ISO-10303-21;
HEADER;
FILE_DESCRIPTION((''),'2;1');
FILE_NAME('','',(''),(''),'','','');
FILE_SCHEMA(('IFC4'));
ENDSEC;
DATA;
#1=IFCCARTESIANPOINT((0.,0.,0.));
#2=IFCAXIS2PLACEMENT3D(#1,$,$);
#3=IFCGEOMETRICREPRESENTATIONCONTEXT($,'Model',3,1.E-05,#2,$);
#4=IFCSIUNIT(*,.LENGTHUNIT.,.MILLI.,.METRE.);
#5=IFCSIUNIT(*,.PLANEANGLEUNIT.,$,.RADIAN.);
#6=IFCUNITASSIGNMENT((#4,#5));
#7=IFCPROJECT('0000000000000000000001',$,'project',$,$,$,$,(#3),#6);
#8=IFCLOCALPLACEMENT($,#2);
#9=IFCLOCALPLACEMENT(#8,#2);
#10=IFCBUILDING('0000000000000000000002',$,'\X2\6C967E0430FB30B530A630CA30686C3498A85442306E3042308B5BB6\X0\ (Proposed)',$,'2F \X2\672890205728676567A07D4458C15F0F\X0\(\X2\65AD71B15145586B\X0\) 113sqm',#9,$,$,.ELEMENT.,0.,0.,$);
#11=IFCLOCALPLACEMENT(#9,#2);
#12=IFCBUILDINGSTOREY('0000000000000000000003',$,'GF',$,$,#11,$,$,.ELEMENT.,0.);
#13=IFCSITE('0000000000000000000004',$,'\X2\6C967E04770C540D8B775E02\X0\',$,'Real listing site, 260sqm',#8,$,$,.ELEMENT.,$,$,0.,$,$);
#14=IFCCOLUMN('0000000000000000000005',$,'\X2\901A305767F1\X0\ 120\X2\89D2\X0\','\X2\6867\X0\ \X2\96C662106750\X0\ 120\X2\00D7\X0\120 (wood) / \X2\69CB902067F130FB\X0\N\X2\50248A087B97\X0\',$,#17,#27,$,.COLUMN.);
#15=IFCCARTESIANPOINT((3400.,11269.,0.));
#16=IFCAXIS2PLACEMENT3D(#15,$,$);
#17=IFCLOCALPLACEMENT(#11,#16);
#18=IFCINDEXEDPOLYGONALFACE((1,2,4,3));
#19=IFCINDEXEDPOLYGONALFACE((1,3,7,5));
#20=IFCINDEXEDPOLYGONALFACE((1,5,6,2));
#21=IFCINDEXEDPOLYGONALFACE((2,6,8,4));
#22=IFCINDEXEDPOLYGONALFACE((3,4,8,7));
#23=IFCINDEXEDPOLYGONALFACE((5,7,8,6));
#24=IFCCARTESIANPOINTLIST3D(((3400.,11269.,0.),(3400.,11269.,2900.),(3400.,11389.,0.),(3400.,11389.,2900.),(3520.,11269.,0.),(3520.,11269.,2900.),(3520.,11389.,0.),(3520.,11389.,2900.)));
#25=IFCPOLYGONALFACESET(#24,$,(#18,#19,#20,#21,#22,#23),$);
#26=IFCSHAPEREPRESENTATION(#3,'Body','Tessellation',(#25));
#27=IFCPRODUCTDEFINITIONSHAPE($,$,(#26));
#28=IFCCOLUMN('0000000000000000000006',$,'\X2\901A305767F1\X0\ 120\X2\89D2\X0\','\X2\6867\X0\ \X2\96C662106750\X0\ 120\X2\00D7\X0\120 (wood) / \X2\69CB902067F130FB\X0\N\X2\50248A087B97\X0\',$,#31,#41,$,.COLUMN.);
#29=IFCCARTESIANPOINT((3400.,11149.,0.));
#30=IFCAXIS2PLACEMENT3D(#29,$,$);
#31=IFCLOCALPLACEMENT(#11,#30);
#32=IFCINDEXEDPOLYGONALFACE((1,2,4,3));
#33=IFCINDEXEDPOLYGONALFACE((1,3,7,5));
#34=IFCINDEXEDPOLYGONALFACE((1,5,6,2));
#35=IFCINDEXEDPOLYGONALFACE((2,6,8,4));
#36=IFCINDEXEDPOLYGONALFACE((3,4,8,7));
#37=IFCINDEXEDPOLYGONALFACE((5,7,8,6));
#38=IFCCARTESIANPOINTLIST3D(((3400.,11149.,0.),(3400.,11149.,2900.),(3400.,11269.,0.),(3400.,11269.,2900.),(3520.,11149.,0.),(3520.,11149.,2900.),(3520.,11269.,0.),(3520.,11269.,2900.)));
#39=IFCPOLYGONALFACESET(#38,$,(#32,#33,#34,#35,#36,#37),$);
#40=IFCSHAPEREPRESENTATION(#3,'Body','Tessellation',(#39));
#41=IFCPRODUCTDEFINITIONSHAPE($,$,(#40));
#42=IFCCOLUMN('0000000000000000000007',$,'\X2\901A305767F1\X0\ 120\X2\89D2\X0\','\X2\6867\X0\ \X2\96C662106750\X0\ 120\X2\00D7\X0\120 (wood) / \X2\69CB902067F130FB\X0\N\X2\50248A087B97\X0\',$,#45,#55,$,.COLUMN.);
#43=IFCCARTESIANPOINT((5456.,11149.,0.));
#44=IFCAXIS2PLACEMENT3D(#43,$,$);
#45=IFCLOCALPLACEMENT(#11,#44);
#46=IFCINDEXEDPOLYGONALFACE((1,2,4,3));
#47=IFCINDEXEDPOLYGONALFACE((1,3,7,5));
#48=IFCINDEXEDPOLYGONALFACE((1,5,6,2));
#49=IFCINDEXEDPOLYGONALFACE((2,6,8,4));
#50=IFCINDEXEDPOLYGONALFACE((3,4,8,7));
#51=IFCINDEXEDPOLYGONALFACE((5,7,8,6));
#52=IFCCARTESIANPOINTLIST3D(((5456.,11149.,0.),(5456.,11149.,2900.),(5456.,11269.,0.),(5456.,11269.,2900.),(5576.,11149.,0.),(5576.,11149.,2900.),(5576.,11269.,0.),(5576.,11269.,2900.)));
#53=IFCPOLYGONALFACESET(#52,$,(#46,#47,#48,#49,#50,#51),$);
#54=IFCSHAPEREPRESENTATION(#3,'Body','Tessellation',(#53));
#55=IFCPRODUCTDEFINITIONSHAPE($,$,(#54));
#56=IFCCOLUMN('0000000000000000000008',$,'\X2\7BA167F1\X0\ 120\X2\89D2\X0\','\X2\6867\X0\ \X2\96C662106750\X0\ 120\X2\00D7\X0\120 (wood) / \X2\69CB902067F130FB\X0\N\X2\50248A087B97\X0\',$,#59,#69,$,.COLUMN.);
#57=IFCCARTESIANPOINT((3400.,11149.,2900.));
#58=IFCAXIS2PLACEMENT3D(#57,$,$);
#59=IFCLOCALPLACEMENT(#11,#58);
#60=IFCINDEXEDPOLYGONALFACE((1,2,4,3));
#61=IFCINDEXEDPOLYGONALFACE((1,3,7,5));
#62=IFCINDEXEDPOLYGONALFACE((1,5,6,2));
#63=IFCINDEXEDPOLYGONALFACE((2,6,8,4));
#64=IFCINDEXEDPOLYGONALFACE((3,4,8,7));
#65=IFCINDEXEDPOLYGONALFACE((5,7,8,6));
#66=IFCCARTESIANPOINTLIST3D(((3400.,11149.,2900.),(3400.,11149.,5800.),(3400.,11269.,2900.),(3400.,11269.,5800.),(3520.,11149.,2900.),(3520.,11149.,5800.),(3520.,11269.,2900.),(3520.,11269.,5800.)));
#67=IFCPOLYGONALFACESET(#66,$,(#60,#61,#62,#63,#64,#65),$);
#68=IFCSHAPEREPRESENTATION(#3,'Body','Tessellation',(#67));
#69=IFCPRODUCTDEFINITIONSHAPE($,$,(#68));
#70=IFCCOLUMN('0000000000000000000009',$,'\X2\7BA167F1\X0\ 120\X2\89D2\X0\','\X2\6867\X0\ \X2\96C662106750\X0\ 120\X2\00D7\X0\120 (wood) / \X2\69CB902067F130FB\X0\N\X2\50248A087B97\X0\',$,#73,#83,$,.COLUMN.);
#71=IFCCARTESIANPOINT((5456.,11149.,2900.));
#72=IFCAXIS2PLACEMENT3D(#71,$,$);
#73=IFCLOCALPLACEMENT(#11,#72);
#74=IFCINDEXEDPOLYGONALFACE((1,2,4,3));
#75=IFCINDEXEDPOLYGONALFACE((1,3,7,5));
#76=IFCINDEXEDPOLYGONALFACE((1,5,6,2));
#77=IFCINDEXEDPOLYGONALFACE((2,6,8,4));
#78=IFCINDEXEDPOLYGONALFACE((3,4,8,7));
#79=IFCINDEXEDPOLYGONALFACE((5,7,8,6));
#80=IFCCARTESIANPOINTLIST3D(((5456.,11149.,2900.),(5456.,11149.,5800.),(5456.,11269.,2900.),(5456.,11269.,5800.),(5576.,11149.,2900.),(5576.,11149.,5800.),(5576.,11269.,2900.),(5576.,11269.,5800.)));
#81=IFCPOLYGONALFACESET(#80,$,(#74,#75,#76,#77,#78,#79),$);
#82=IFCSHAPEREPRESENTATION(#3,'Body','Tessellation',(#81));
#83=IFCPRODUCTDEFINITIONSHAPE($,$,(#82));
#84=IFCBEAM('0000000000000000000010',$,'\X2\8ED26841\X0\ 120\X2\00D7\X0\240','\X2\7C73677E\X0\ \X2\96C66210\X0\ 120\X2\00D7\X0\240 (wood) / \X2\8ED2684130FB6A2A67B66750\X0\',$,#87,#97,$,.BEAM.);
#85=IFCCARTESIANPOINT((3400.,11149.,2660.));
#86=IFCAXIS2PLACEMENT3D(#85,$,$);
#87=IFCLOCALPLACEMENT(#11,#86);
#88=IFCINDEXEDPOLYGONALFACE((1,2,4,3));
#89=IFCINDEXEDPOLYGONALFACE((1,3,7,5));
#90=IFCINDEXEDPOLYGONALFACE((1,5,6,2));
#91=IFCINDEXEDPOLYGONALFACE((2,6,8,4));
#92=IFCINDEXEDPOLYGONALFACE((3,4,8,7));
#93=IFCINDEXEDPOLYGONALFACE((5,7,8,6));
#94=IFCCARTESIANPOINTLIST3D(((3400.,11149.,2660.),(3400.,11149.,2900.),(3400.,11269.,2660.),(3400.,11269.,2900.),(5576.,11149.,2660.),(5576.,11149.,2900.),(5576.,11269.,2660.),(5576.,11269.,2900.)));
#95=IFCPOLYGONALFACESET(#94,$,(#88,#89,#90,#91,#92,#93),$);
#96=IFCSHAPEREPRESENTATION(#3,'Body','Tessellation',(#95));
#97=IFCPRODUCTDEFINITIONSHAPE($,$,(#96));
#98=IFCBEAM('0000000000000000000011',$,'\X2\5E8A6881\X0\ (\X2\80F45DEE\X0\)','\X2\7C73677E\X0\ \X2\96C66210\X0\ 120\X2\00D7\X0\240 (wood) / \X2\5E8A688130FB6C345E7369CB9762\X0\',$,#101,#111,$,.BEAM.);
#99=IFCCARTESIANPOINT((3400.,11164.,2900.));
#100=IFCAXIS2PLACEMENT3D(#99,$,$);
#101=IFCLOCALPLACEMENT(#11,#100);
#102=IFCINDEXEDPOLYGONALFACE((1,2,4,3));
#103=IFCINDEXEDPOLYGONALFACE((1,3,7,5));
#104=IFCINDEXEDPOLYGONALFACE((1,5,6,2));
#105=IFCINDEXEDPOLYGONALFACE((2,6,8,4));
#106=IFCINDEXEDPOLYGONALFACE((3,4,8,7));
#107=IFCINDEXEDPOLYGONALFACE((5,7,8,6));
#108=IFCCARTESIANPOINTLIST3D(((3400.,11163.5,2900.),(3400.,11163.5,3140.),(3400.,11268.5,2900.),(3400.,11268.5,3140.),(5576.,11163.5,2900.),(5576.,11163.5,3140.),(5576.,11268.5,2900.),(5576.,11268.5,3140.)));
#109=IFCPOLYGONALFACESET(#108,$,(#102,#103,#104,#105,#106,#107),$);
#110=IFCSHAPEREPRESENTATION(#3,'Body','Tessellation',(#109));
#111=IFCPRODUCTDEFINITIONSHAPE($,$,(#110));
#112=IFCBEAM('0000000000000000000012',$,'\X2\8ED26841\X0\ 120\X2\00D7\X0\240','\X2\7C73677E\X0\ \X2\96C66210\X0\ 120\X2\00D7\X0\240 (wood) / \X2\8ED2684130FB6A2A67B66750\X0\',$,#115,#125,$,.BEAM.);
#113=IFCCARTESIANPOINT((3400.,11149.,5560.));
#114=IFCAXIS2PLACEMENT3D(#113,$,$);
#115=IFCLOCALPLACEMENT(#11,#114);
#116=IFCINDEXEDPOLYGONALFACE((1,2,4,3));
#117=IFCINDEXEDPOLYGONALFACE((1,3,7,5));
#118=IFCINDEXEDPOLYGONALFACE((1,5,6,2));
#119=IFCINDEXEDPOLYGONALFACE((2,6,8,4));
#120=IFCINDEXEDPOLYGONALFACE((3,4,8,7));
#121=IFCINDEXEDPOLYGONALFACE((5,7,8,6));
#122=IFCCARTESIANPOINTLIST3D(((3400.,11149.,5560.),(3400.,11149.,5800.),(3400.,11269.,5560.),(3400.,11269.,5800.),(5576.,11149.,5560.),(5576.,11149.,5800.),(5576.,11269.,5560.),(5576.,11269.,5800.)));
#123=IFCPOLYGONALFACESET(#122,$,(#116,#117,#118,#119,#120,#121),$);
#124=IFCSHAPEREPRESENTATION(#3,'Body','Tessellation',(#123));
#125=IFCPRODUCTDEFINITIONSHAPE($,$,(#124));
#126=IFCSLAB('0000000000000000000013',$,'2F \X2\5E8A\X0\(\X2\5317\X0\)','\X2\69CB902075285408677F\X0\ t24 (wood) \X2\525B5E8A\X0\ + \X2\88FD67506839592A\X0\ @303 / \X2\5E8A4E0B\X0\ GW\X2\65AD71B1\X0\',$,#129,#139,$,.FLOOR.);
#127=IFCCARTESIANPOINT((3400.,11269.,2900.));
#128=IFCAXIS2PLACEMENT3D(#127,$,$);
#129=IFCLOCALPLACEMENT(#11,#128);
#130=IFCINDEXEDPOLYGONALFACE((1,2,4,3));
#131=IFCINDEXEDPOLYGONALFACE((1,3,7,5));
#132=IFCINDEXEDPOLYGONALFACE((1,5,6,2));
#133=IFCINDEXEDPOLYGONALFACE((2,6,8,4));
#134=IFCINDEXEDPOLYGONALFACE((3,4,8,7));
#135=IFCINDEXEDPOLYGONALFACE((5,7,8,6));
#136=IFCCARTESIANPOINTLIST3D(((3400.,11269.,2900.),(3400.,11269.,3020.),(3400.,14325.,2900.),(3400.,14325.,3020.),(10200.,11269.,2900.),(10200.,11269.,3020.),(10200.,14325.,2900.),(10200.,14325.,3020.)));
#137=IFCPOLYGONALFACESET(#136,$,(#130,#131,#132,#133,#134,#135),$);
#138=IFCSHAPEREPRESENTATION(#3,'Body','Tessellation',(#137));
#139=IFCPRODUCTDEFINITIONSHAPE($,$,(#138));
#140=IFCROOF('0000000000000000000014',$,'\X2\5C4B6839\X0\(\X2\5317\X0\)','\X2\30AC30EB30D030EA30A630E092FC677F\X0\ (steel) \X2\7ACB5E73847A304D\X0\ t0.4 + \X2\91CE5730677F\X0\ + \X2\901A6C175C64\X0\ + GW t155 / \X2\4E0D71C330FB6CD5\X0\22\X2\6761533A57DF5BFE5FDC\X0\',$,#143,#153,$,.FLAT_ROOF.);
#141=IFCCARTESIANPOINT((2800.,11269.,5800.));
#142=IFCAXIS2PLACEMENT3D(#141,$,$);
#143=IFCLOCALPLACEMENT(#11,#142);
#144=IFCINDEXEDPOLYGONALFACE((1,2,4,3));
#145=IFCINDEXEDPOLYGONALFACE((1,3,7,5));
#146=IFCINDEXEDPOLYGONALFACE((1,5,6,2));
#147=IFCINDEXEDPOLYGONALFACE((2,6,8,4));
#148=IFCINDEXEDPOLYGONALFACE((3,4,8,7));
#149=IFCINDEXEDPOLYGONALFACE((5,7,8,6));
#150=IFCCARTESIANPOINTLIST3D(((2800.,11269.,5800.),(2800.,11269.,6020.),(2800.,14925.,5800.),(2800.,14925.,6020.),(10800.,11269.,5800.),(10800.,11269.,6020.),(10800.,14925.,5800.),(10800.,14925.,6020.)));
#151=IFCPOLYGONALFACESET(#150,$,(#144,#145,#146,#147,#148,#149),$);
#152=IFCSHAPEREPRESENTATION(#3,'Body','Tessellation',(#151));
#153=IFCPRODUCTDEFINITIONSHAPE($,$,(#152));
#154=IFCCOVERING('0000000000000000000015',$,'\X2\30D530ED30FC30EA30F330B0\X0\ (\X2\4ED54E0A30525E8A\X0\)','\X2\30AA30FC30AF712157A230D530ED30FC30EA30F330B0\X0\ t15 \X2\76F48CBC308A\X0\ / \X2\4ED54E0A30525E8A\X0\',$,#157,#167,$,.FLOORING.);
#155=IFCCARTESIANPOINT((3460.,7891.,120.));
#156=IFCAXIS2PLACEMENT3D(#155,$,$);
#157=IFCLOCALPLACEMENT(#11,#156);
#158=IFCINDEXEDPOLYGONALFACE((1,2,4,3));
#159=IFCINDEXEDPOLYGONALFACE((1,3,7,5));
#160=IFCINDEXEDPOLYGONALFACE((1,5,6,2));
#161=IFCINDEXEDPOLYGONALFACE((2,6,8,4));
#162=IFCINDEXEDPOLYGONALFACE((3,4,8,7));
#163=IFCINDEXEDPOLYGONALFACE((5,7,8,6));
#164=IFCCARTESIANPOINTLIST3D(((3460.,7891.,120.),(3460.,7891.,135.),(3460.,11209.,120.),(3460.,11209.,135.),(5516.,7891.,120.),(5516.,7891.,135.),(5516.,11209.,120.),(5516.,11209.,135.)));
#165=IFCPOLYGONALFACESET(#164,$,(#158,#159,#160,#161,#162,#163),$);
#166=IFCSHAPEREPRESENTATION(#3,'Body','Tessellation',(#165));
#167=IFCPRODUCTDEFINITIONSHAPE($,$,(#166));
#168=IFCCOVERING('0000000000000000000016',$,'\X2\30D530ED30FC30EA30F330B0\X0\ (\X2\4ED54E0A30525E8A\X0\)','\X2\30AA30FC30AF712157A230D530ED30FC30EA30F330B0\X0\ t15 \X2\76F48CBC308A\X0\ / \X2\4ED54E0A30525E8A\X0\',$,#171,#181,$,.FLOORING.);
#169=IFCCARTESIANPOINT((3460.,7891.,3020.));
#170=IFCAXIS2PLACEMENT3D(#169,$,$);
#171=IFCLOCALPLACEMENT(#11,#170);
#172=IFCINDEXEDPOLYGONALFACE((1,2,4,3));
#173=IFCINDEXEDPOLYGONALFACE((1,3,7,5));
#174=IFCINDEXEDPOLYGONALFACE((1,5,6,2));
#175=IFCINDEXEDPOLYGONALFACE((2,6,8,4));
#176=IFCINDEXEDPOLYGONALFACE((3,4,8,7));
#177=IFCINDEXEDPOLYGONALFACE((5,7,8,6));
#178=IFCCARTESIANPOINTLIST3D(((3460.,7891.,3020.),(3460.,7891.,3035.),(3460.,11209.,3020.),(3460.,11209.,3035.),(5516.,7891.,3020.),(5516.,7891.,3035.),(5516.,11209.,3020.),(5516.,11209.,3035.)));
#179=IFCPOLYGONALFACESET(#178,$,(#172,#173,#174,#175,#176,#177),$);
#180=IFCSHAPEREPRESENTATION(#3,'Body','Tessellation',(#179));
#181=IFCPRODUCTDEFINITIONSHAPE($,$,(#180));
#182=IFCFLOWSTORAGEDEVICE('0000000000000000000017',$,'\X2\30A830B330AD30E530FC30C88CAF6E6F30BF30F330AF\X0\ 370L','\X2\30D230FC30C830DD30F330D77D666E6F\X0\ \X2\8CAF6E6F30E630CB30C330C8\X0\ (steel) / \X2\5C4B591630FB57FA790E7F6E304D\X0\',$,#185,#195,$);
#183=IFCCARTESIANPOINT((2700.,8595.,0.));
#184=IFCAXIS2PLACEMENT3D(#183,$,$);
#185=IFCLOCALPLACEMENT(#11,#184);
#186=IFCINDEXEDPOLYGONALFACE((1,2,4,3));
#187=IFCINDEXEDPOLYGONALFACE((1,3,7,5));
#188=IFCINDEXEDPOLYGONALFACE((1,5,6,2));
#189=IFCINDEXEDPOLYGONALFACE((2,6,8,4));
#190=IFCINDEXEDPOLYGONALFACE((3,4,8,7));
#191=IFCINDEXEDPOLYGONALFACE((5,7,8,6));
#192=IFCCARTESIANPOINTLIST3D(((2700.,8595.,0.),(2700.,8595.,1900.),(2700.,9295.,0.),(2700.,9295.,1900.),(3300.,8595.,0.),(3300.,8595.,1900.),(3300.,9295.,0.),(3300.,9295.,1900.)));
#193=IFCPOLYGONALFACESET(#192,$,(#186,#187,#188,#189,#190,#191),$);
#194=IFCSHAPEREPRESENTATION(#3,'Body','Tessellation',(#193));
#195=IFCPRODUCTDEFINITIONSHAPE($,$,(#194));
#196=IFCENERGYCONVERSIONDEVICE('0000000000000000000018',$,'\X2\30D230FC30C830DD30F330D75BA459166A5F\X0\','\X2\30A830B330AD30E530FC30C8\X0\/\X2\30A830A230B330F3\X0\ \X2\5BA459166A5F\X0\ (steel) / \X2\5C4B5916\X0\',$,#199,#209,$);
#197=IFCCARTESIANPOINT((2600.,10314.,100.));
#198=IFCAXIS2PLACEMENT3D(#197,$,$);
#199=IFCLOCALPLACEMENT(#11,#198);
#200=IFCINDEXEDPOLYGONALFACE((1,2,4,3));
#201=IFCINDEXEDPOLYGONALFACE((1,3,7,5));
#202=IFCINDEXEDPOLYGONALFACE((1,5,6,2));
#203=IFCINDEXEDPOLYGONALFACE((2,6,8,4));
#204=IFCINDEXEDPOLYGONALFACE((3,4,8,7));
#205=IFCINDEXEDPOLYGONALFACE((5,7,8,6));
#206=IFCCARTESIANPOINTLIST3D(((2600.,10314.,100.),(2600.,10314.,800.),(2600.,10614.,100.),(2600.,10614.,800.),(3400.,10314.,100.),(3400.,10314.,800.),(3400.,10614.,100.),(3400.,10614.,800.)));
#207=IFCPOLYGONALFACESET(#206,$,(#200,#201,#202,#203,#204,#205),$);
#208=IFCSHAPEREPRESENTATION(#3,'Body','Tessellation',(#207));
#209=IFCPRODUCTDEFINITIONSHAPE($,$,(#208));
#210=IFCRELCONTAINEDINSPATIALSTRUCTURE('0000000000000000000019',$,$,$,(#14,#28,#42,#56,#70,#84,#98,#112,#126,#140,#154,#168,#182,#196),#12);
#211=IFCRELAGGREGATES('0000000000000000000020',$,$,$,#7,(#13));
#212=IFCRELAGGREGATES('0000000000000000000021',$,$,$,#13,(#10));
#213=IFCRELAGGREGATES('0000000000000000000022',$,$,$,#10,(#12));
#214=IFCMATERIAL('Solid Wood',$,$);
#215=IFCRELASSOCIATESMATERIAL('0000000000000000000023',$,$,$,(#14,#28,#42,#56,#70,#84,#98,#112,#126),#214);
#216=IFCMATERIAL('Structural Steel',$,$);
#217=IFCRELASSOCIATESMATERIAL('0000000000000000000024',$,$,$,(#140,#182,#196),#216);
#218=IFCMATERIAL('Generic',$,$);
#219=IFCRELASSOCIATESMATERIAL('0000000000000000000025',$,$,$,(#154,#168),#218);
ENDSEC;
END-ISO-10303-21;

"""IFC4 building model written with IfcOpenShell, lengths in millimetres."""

from ifc_helpers import new_model, si_unit, frame, frame_2d, origin, place, context, project, spatial, rectangle, extrude, material, element, save


model = new_model("IFC4")

# Units and contexts
model_context = context("Model", 3, precision=1e-05, world=origin())
ifc_project = project(units=[si_unit("LENGTHUNIT", "METRE", prefix="MILLI"), si_unit("PLANEANGLEUNIT", "RADIAN")], contexts=[model_context])

# Site, building, storey
site_placement = place(None, origin())
site = spatial("IfcSite", under=ifc_project, at=site_placement, Name="沖縄県名護市", ObjectType="Real listing site, 260sqm", CompositionType="ELEMENT", RefElevation=0.0)
building_placement = place(site_placement, origin())
building = spatial("IfcBuilding", under=site, at=building_placement, Name="沖縄・サウナと水風呂のある家 (Proposed)", ObjectType="2F 木造在来枠組壁式(断熱充填) 113sqm", CompositionType="ELEMENT", ElevationOfRefHeight=0.0, ElevationOfTerrain=0.0)
storey_placement = place(building_placement, origin())
storey = spatial("IfcBuildingStorey", under=building, at=storey_placement, Name="GF", CompositionType="ELEMENT", Elevation=0.0)

# Columns
ifc_material_1 = material(Name="Solid Wood")
column_1_placement = place(storey_placement, frame((3400.0, 11269.0, 0.0)))
element("IfcColumn", 1, at=column_1_placement, inside=storey, material=ifc_material_1, Name="通し柱 120角", Description="桧 集成材 120×120 (wood) / 構造柱・N値計算", PredefinedType="COLUMN", context=model_context, shape_type="SweptSolid", body=[
    extrude(rectangle(XDim=120.0, YDim=120.0, at=frame_2d((60.0, 60.0))), frame((3400.0, 11269.0, 0.0)), (0.0, 0.0, 1.0), 2900.0),
])
column_2_placement = place(storey_placement, frame((3400.0, 11149.0, 0.0)))
element("IfcColumn", 2, at=column_2_placement, inside=storey, material=ifc_material_1, Name="通し柱 120角", Description="桧 集成材 120×120 (wood) / 構造柱・N値計算", PredefinedType="COLUMN", context=model_context, shape_type="SweptSolid", body=[
    extrude(rectangle(XDim=120.0, YDim=120.0, at=frame_2d((60.0, 60.0))), frame((3400.0, 11149.0, 0.0)), (0.0, 0.0, 1.0), 2900.0),
])
column_3_placement = place(storey_placement, frame((5456.0, 11149.0, 0.0)))
element("IfcColumn", 3, at=column_3_placement, inside=storey, material=ifc_material_1, Name="通し柱 120角", Description="桧 集成材 120×120 (wood) / 構造柱・N値計算", PredefinedType="COLUMN", context=model_context, shape_type="SweptSolid", body=[
    extrude(rectangle(XDim=120.0, YDim=120.0, at=frame_2d((60.0, 60.0))), frame((5456.0, 11149.0, 0.0)), (0.0, 0.0, 1.0), 2900.0),
])
column_4_placement = place(storey_placement, frame((3400.0, 11149.0, 2900.0)))
element("IfcColumn", 4, at=column_4_placement, inside=storey, material=ifc_material_1, Name="管柱 120角", Description="桧 集成材 120×120 (wood) / 構造柱・N値計算", PredefinedType="COLUMN", context=model_context, shape_type="SweptSolid", body=[
    extrude(rectangle(XDim=120.0, YDim=120.0, at=frame_2d((60.0, 60.0))), frame((3400.0, 11149.0, 2900.0)), (0.0, 0.0, 1.0), 2900.0),
])
column_5_placement = place(storey_placement, frame((5456.0, 11149.0, 2900.0)))
element("IfcColumn", 5, at=column_5_placement, inside=storey, material=ifc_material_1, Name="管柱 120角", Description="桧 集成材 120×120 (wood) / 構造柱・N値計算", PredefinedType="COLUMN", context=model_context, shape_type="SweptSolid", body=[
    extrude(rectangle(XDim=120.0, YDim=120.0, at=frame_2d((60.0, 60.0))), frame((5456.0, 11149.0, 2900.0)), (0.0, 0.0, 1.0), 2900.0),
])

# Beams
beam_1_placement = place(storey_placement, frame((3400.0, 11149.0, 2660.0)))
element("IfcBeam", 6, at=beam_1_placement, inside=storey, material=ifc_material_1, Name="軒桁 120×240", Description="米松 集成 120×240 (wood) / 軒桁・横架材", PredefinedType="BEAM", context=model_context, shape_type="SweptSolid", body=[
    extrude(rectangle(XDim=2176.0, YDim=120.0, at=frame_2d((1088.0, 60.0))), frame((3400.0, 11149.0, 2660.0)), (0.0, 0.0, 1.0), 240.0),
])
beam_2_placement = place(storey_placement, frame((3400.0, 11164.0, 2900.0)))
element("IfcBeam", 7, at=beam_2_placement, inside=storey, material=ifc_material_1, Name="床梁 (胴差)", Description="米松 集成 120×240 (wood) / 床梁・水平構面", PredefinedType="BEAM", context=model_context, shape_type="SweptSolid", body=[
    extrude(rectangle(XDim=2176.0, YDim=105.0, at=frame_2d((1088.0, 52.0))), frame((3400.0, 11164.0, 2900.0)), (0.0, 0.0, 1.0), 240.0),
])
beam_3_placement = place(storey_placement, frame((3400.0, 11149.0, 5560.0)))
element("IfcBeam", 8, at=beam_3_placement, inside=storey, material=ifc_material_1, Name="軒桁 120×240", Description="米松 集成 120×240 (wood) / 軒桁・横架材", PredefinedType="BEAM", context=model_context, shape_type="SweptSolid", body=[
    extrude(rectangle(XDim=2176.0, YDim=120.0, at=frame_2d((1088.0, 60.0))), frame((3400.0, 11149.0, 5560.0)), (0.0, 0.0, 1.0), 240.0),
])

# Slab
slab_1_placement = place(storey_placement, frame((3400.0, 11269.0, 2900.0)))
element("IfcSlab", 9, at=slab_1_placement, inside=storey, material=ifc_material_1, Name="2F 床(北)", Description="構造用合板 t24 (wood) 剛床 + 製材根太 @303 / 床下 GW断熱", PredefinedType="FLOOR", context=model_context, shape_type="SweptSolid", body=[
    extrude(rectangle(XDim=6800.0, YDim=3056.0, at=frame_2d((3400.0, 1528.0))), frame((3400.0, 11269.0, 2900.0)), (0.0, 0.0, 1.0), 120.0),
])

# Roof
ifc_material_2 = material(Name="Structural Steel")
for number, where, name in (
    (10, (2800.0, 11269.0, 5800.0), "屋根(北)"),
):
    element("IfcRoof", number, at=place(storey_placement, frame(where)), inside=storey, material=ifc_material_2, Name=name, Description="ガルバリウム鋼板 (steel) 立平葺き t0.4 + 野地板 + 通気層 + GW t155 / 不燃・法22条区域対応", PredefinedType="FLAT_ROOF", context=model_context, shape_type="SweptSolid", body=[
        extrude(rectangle(XDim=8000.0, YDim=3656.0, at=frame_2d((4000.0, 1828.0))), frame((2800.0, 11269.0, 5800.0)), (0.0, 0.0, 1.0), 220.0),
    ])

# Coverings
ifc_material_3 = material(Name="Generic")
covering_1_placement = place(storey_placement, frame((3460.0, 7891.0, 120.0)))
element("IfcCovering", 11, at=covering_1_placement, inside=storey, material=ifc_material_3, Name="フローリング (仕上げ床)", Description="オーク無垢フローリング t15 直貼り / 仕上げ床", PredefinedType="FLOORING", context=model_context, shape_type="SweptSolid", body=[
    extrude(rectangle(XDim=2056.0, YDim=3318.0, at=frame_2d((1028.0, 1659.0))), frame((3460.0, 7891.0, 120.0)), (0.0, 0.0, 1.0), 15.0),
])
covering_2_placement = place(storey_placement, frame((3460.0, 7891.0, 3020.0)))
element("IfcCovering", 12, at=covering_2_placement, inside=storey, material=ifc_material_3, Name="フローリング (仕上げ床)", Description="オーク無垢フローリング t15 直貼り / 仕上げ床", PredefinedType="FLOORING", context=model_context, shape_type="SweptSolid", body=[
    extrude(rectangle(XDim=2056.0, YDim=3318.0, at=frame_2d((1028.0, 1659.0))), frame((3460.0, 7891.0, 3020.0)), (0.0, 0.0, 1.0), 15.0),
])

# Flow storage device
flow_storage_device_placement = place(storey_placement, frame((2700.0, 8595.0, 0.0)))
element("IfcFlowStorageDevice", 13, at=flow_storage_device_placement, inside=storey, material=ifc_material_2, Name="エコキュート貯湯タンク 370L", Description="ヒートポンプ給湯 貯湯ユニット (steel) / 屋外・基礎置き", context=model_context, shape_type="SweptSolid", body=[
    extrude(rectangle(XDim=600.0, YDim=700.0, at=frame_2d((300.0, 350.0))), frame((2700.0, 8595.0, 0.0)), (0.0, 0.0, 1.0), 1900.0),
])

# Energy conversion device
energy_conversion_device_placement = place(storey_placement, frame((2600.0, 10314.0, 100.0)))
element("IfcEnergyConversionDevice", 14, at=energy_conversion_device_placement, inside=storey, material=ifc_material_2, Name="ヒートポンプ室外機", Description="エコキュート/エアコン 室外機 (steel) / 屋外", context=model_context, shape_type="SweptSolid", body=[
    extrude(rectangle(XDim=800.0, YDim=300.0, at=frame_2d((400.0, 150.0))), frame((2600.0, 10314.0, 100.0)), (0.0, 0.0, 1.0), 700.0),
])

save(model, "model.ifc")
